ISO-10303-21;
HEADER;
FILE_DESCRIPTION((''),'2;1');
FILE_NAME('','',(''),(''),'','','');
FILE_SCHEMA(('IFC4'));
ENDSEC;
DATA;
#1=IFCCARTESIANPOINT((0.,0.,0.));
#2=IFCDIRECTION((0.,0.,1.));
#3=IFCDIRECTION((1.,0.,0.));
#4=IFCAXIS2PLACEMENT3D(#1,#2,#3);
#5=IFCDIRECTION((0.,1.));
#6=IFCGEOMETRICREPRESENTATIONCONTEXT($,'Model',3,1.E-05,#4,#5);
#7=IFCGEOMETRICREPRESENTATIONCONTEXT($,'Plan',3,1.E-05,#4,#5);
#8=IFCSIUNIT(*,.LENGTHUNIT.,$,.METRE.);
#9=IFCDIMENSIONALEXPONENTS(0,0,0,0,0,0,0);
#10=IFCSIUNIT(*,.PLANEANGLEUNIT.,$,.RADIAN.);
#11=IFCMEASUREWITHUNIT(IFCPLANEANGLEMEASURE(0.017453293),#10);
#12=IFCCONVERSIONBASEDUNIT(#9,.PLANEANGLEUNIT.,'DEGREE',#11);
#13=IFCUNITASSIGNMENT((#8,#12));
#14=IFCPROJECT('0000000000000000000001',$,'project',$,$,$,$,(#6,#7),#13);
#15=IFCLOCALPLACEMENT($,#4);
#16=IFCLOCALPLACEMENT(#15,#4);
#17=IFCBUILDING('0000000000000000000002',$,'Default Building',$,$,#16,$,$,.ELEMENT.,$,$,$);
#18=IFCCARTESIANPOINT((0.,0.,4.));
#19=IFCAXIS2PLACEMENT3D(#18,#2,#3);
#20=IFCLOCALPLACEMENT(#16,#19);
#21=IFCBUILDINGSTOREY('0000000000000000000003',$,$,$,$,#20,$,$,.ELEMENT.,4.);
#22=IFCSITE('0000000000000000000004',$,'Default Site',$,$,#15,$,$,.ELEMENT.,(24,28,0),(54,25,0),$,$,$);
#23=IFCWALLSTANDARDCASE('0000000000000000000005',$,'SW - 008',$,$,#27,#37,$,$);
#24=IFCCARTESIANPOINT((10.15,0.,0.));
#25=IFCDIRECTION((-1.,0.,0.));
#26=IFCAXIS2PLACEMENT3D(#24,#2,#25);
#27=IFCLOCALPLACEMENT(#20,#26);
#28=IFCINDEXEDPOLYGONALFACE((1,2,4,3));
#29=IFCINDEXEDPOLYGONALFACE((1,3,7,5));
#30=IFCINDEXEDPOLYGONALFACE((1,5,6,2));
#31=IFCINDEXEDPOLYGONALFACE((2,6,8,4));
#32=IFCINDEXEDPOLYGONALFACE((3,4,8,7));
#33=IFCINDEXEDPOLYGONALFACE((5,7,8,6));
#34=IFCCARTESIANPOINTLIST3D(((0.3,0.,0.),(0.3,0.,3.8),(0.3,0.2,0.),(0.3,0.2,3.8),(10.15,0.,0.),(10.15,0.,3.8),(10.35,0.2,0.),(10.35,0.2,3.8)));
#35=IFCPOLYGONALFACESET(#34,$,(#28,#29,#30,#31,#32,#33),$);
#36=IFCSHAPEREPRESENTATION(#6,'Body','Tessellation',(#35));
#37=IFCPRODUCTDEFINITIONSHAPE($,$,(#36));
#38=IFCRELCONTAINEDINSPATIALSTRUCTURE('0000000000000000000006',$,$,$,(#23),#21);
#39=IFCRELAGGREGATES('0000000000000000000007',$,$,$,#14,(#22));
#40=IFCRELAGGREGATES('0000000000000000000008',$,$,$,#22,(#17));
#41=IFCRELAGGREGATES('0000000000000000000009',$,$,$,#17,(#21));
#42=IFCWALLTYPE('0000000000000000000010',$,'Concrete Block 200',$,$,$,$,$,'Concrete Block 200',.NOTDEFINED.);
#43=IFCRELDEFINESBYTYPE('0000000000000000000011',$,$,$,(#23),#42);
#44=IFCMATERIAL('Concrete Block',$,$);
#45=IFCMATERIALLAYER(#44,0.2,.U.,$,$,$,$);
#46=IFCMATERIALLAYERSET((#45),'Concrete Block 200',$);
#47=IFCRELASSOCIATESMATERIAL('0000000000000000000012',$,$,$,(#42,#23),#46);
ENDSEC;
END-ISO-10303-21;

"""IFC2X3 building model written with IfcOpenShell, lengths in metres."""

from ifc_helpers import new_model, entity, si_unit, converted_unit, direction, frame, origin_with_axes, place, context, project, spatial, polyline, outline, extrude, material, layer, layer_set, layer_usage, type_object, element, save


model = new_model("IFC2X3")

# Units and contexts
model_context = context("Model", 3, precision=1e-05, world=origin_with_axes(), true_north=direction((0.0, 1.0)))
plan_context = context("Plan", 3, precision=1e-05, world=origin_with_axes(), true_north=direction((0.0, 1.0)))
ifc_project = project(units=[si_unit("LENGTHUNIT", "METRE"), converted_unit("PLANEANGLEUNIT", "DEGREE", entity("IfcPlaneAngleMeasure", 0.017453293), si_unit("PLANEANGLEUNIT", "RADIAN"), dimensions=[0, 0, 0, 0, 0, 0, 0])], contexts=[model_context, plan_context])

# Site, building, storey
site_placement = place(None, origin_with_axes())
site = spatial("IfcSite", under=ifc_project, at=site_placement, Name="Default Site", CompositionType="ELEMENT", RefLatitude=(24, 28, 0), RefLongitude=(54, 25, 0))
building_placement = place(site_placement, origin_with_axes())
building = spatial("IfcBuilding", under=site, at=building_placement, Name="Default Building", CompositionType="ELEMENT")
storey_placement = place(building_placement, frame((0.0, 0.0, 4.0), z_axis=(0.0, 0.0, 1.0), x_axis=(1.0, 0.0, 0.0)))
storey = spatial("IfcBuildingStorey", under=building, at=storey_placement, CompositionType="ELEMENT", Elevation=4.0)

# Shared definitions
ifc_material = material(Name="Concrete Block")
ifc_layer_1 = layer(ifc_material, 0.2, ventilated="UNKNOWN")
ifc_layer_set_1 = layer_set([ifc_layer_1], Name="Concrete Block 200")

# Wall
wall_type_1 = type_object("IfcWallType", Name="Concrete Block 200", ElementType="Concrete Block 200", PredefinedType="NOTDEFINED", material=ifc_layer_set_1)
ifc_layer_usage_1 = layer_usage(ifc_layer_set_1, "AXIS2", "POSITIVE", 0.0)
wall_1_placement = place(storey_placement, frame((10.15, 0.0, 0.0), z_axis=(0.0, 0.0, 1.0), x_axis=(-1.0, 0.0, 0.0)))
element("IfcWallStandardCase", 1, at=wall_1_placement, inside=storey, type_object=wall_type_1, material=ifc_layer_usage_1, Name="SW - 008", context=model_context, shape_type="SweptSolid", body=[
    extrude(outline(polyline([(0.3, 0.0), (10.15, 0.0), (10.35, 0.2), (0.3, 0.2), (0.3, 0.0)])), origin_with_axes(), (0.0, 0.0, 1.0), 3.8),
])

save(model, "model.ifc")
